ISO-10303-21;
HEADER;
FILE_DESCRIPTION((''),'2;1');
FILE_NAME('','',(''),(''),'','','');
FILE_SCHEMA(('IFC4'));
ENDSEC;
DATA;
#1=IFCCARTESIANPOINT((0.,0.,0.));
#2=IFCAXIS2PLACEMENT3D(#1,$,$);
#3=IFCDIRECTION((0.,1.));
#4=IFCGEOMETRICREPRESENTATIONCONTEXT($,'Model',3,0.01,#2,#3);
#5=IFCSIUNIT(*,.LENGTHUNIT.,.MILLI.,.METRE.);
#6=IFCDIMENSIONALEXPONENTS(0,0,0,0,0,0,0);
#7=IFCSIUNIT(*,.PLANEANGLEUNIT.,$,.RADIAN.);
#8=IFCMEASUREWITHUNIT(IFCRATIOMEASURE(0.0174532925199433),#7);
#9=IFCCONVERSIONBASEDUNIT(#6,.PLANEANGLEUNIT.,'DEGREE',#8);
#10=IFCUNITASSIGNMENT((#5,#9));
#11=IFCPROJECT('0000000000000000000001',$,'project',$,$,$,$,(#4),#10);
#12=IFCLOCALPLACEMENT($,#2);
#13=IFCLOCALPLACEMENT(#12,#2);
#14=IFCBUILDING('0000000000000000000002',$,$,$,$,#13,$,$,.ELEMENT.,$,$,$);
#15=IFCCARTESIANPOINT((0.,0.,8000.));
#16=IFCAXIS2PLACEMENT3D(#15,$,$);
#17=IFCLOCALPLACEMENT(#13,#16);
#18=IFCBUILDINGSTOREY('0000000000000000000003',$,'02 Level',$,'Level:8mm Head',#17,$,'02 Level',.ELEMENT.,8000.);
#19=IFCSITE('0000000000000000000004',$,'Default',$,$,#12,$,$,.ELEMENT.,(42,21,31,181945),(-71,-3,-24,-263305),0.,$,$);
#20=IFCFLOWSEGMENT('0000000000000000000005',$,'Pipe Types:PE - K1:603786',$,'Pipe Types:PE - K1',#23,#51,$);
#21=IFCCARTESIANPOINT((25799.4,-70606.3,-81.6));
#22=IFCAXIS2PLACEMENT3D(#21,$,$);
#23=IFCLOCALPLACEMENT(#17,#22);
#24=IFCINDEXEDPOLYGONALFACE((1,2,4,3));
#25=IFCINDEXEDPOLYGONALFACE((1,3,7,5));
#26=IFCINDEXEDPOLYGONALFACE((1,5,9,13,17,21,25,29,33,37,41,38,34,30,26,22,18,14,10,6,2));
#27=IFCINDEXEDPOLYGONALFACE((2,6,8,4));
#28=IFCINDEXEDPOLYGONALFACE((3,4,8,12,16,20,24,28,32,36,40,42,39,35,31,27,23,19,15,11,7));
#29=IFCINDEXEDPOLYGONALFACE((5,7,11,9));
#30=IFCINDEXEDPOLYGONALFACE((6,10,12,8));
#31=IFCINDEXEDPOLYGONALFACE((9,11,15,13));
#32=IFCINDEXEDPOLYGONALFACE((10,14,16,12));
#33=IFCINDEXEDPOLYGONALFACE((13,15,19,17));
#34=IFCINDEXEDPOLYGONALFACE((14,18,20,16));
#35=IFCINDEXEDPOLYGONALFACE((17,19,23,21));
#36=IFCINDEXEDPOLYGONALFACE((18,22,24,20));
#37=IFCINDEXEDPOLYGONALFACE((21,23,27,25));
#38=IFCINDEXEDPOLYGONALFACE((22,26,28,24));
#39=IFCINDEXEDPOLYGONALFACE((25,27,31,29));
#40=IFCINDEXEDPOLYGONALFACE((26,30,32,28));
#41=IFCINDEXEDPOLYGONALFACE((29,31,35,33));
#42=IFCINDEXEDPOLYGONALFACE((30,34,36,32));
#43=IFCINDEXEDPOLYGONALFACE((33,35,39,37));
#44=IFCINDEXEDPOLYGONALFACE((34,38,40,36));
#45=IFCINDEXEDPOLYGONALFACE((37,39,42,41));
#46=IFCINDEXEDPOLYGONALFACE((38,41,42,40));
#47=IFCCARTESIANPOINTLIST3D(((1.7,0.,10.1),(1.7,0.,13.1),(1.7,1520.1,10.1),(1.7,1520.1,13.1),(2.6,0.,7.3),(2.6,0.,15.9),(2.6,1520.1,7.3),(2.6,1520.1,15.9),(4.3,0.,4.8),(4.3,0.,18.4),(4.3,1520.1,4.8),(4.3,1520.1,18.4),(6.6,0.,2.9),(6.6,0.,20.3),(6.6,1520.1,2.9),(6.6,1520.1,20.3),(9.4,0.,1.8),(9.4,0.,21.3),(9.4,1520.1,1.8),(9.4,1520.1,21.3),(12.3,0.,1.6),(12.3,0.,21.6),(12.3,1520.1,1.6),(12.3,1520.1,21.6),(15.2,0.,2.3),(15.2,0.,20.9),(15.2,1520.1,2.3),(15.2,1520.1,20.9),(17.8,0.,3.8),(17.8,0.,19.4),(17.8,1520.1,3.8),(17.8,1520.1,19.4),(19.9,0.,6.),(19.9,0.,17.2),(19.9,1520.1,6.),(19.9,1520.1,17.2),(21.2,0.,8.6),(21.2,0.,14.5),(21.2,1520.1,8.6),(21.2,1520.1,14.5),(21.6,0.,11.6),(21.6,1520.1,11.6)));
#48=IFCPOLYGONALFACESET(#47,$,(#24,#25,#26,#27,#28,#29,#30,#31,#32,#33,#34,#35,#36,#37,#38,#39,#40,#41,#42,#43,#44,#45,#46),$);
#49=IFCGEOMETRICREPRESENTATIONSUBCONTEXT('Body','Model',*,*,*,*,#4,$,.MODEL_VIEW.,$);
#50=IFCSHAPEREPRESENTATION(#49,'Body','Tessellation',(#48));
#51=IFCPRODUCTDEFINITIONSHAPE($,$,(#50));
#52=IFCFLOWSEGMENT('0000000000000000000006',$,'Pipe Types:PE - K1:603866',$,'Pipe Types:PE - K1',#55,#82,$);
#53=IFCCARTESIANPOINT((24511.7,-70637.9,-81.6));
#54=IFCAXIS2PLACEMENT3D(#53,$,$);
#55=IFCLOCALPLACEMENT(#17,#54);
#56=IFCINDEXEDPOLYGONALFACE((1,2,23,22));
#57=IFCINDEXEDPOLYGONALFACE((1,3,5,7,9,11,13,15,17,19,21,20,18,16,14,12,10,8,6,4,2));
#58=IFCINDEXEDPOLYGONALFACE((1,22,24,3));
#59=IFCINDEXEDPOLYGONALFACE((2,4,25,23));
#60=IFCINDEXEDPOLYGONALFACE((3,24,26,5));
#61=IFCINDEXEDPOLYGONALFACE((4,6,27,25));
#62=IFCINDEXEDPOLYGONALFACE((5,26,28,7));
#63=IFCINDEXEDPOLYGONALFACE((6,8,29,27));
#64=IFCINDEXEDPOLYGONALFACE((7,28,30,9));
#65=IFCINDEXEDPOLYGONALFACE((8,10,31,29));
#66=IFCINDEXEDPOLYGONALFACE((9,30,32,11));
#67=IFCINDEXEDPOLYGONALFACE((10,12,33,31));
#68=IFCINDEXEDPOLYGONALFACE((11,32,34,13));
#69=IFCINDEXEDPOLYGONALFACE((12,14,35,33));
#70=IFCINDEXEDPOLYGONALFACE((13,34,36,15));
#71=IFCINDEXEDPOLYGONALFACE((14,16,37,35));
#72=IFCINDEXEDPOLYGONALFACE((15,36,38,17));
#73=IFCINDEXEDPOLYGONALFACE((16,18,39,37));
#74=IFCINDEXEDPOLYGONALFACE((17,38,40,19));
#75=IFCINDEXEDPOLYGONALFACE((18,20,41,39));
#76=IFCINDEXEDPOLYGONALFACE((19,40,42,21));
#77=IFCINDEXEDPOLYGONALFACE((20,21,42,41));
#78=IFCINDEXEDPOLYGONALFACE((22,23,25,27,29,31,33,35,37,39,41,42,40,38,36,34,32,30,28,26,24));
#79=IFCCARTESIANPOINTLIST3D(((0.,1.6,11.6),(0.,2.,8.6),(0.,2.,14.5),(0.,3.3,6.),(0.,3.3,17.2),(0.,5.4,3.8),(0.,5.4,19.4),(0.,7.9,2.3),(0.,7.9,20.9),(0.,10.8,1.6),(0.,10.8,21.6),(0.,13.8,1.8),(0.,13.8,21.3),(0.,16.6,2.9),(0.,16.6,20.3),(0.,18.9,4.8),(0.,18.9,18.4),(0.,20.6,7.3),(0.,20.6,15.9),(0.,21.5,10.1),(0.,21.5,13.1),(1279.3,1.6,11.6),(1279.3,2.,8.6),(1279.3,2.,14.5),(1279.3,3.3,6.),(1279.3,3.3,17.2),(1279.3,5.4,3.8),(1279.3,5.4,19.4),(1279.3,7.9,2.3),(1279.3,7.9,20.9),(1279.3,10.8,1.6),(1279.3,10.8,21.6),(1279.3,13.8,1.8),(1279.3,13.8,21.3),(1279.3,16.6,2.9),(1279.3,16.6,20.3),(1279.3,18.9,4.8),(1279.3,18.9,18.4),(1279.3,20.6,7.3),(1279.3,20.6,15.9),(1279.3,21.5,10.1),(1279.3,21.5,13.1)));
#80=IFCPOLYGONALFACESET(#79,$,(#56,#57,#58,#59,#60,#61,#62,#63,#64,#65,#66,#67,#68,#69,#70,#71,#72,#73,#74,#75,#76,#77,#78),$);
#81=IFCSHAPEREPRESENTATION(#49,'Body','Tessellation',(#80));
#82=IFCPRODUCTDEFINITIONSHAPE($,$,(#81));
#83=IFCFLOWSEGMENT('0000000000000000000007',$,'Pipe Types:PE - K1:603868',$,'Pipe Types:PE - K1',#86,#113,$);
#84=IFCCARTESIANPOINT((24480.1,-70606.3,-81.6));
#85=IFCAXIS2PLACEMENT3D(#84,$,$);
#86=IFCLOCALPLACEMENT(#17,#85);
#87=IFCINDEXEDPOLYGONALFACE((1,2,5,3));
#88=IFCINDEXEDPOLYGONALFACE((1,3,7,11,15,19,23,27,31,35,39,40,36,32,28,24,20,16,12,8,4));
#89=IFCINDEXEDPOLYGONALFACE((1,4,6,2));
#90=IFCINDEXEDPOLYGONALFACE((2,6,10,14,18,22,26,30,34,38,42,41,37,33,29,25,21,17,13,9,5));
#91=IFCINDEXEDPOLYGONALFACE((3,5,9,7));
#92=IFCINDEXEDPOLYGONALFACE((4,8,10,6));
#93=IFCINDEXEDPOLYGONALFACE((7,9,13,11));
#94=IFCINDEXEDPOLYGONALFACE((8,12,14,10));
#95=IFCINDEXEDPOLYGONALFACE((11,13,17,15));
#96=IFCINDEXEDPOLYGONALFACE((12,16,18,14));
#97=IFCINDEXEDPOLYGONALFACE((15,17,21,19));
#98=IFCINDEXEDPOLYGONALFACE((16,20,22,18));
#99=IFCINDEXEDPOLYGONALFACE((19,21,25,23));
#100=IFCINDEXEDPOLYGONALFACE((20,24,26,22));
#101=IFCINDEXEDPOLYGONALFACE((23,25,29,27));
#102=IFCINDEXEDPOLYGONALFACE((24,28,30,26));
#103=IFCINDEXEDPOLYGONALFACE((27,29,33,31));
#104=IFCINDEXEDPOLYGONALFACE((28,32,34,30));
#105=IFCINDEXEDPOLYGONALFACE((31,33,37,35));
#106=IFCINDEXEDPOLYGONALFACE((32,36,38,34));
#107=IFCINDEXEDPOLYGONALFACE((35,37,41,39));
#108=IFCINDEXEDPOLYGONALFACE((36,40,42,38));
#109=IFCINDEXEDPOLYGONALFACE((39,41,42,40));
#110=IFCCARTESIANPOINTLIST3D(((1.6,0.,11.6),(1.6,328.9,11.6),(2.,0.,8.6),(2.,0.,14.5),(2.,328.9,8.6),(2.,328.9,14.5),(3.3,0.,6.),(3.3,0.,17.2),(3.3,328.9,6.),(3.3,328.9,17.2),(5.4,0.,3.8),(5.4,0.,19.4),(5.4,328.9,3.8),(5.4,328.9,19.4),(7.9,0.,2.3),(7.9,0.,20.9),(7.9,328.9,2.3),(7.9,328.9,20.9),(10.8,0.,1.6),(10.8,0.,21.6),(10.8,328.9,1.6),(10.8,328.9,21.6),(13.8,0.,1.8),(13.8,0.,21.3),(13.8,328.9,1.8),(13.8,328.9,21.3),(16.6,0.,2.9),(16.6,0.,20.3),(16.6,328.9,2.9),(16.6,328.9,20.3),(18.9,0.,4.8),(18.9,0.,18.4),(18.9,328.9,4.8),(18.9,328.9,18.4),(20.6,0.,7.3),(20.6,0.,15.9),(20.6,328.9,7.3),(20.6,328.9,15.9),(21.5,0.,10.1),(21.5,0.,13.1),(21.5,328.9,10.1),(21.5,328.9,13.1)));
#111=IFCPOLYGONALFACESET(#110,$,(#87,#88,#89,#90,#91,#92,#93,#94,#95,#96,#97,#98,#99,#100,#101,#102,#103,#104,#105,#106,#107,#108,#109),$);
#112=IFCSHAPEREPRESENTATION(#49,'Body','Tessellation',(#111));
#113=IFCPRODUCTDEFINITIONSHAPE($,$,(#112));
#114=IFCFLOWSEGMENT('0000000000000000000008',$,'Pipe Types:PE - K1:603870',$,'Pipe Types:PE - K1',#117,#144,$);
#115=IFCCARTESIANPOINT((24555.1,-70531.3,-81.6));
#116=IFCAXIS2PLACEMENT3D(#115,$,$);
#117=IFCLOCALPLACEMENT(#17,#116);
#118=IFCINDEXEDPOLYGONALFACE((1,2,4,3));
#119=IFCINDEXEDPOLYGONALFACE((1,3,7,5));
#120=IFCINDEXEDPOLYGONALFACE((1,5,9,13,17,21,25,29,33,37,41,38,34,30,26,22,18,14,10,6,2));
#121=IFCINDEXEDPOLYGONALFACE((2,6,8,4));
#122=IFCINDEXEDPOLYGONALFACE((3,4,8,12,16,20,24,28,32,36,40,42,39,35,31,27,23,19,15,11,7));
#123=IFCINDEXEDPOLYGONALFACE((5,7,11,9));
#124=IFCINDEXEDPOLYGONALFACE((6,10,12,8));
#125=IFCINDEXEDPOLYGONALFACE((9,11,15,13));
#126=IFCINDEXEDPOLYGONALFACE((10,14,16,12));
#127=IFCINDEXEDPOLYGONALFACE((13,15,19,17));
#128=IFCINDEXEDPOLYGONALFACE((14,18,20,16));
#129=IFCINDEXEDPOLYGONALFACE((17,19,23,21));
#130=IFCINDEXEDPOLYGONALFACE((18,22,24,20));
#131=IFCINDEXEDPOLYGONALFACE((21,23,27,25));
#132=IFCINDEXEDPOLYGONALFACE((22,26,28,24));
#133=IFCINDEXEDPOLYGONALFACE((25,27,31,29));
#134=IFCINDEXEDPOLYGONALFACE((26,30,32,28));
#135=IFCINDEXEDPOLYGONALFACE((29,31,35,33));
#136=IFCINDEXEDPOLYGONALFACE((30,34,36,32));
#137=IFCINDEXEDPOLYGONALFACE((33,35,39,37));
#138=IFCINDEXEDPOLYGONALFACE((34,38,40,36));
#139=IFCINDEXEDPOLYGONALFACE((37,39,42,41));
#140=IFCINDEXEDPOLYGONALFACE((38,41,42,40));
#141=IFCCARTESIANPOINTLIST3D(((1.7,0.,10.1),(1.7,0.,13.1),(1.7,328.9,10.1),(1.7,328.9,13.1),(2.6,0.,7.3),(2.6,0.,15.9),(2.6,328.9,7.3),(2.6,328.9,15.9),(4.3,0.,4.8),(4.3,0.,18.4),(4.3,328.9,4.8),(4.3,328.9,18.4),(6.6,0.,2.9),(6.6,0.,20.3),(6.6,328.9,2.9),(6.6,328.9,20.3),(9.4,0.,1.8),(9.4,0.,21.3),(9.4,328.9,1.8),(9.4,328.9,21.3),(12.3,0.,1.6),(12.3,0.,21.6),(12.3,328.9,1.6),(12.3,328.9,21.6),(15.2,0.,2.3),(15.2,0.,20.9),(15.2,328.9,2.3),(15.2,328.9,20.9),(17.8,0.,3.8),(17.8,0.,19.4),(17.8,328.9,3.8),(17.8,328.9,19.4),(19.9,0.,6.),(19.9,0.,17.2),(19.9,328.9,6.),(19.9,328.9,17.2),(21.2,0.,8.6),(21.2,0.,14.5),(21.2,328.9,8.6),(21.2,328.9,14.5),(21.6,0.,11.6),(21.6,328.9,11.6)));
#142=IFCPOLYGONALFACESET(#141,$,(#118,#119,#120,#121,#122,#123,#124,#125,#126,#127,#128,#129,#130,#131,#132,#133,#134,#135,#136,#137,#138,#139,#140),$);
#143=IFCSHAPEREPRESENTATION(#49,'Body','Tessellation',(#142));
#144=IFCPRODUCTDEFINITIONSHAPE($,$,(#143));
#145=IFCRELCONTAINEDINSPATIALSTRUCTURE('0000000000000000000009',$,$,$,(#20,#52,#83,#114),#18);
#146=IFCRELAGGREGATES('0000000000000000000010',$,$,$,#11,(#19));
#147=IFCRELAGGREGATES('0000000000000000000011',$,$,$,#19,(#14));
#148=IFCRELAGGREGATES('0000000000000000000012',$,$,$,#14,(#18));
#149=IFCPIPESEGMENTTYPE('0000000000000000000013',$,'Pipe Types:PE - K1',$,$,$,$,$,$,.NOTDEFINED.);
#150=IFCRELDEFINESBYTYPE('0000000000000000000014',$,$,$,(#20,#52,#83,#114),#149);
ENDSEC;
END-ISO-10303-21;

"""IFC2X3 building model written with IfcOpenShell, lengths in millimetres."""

from ifc_helpers import new_model, entity, si_unit, converted_unit, direction, frame, frame_2d, origin, origin_2d_with_axis, place, context, subcontext, project, spatial, circle, extrude, type_object, element, save


model = new_model("IFC2X3")

# Units and contexts
model_context = context("Model", 3, precision=0.01, world=origin(), true_north=direction((0.0, 1.0)))
body_context = subcontext(model_context, "Body", "Model", "MODEL_VIEW")
ifc_project = project(units=[si_unit("LENGTHUNIT", "METRE", prefix="MILLI"), converted_unit("PLANEANGLEUNIT", "DEGREE", entity("IfcRatioMeasure", 0.0174532925199433), si_unit("PLANEANGLEUNIT", "RADIAN"), dimensions=[0, 0, 0, 0, 0, 0, 0])], contexts=[model_context])

# Site, building, storey
site_placement = place(None, origin())
site = spatial("IfcSite", under=ifc_project, at=site_placement, Name="Default", CompositionType="ELEMENT", RefLatitude=(42, 21, 31, 181945), RefLongitude=(-71, -3, -24, -263305), RefElevation=0.0)
building_placement = place(site_placement, origin())
building = spatial("IfcBuilding", under=site, at=building_placement, CompositionType="ELEMENT")
storey_placement = place(building_placement, frame((0.0, 0.0, 8000.0)))
storey = spatial("IfcBuildingStorey", under=building, at=storey_placement, Name="02 Level", ObjectType="Level:8mm Head", LongName="02 Level", CompositionType="ELEMENT", Elevation=8000.0)

# Flow segments
pipe_segment_type = type_object("IfcPipeSegmentType", Name="Pipe Types:PE - K1", PredefinedType="NOTDEFINED")
flow_segment_1_placement = place(storey_placement, frame((25799.4, -70606.3, -81.6)))
element("IfcFlowSegment", 1, at=flow_segment_1_placement, inside=storey, type_object=pipe_segment_type, Name="Pipe Types:PE - K1:603786", ObjectType="Pipe Types:PE - K1", context=body_context, shape_type="SweptSolid", body=[
    extrude(circle(Radius=10.0, at=origin_2d_with_axis()), frame((11.6, 0.0, 11.6), z_axis=(0.0, 1.0, 0.0), x_axis=(1.0, 0.0, 0.0)), (0.0, 0.0, 1.0), 1520.1),
])
flow_segment_2_placement = place(storey_placement, frame((24511.7, -70637.9, -81.6)))
element("IfcFlowSegment", 2, at=flow_segment_2_placement, inside=storey, type_object=pipe_segment_type, Name="Pipe Types:PE - K1:603866", ObjectType="Pipe Types:PE - K1", context=body_context, shape_type="SweptSolid", body=[
    extrude(circle(Radius=10.0, at=origin_2d_with_axis()), frame((0.0, 11.6, 11.6), z_axis=(1.0, 0.0, 0.0), x_axis=(0.0, -1.0, 0.0)), (0.0, 0.0, 1.0), 1279.3),
])
flow_segment_3_placement = place(storey_placement, frame((24480.1, -70606.3, -81.6)))
element("IfcFlowSegment", 3, at=flow_segment_3_placement, inside=storey, type_object=pipe_segment_type, Name="Pipe Types:PE - K1:603868", ObjectType="Pipe Types:PE - K1", context=body_context, shape_type="SweptSolid", body=[
    extrude(circle(Radius=10.0, at=frame_2d((0.0, 0.0), x_axis=(1.0, 0.0))), frame((11.6, 0.0, 11.6), z_axis=(0.0, 1.0, 0.0), x_axis=(-1.0, 0.0, 0.0)), (0.0, 0.0, 1.0), 328.9),
])
flow_segment_4_placement = place(storey_placement, frame((24555.1, -70531.3, -81.6)))
element("IfcFlowSegment", 4, at=flow_segment_4_placement, inside=storey, type_object=pipe_segment_type, Name="Pipe Types:PE - K1:603870", ObjectType="Pipe Types:PE - K1", context=body_context, shape_type="SweptSolid", body=[
    extrude(circle(Radius=10.0, at=origin_2d_with_axis()), frame((11.6, 0.0, 11.6), z_axis=(0.0, 1.0, 0.0), x_axis=(1.0, 0.0, 0.0)), (0.0, 0.0, 1.0), 328.9),
])

save(model, "model.ifc")
